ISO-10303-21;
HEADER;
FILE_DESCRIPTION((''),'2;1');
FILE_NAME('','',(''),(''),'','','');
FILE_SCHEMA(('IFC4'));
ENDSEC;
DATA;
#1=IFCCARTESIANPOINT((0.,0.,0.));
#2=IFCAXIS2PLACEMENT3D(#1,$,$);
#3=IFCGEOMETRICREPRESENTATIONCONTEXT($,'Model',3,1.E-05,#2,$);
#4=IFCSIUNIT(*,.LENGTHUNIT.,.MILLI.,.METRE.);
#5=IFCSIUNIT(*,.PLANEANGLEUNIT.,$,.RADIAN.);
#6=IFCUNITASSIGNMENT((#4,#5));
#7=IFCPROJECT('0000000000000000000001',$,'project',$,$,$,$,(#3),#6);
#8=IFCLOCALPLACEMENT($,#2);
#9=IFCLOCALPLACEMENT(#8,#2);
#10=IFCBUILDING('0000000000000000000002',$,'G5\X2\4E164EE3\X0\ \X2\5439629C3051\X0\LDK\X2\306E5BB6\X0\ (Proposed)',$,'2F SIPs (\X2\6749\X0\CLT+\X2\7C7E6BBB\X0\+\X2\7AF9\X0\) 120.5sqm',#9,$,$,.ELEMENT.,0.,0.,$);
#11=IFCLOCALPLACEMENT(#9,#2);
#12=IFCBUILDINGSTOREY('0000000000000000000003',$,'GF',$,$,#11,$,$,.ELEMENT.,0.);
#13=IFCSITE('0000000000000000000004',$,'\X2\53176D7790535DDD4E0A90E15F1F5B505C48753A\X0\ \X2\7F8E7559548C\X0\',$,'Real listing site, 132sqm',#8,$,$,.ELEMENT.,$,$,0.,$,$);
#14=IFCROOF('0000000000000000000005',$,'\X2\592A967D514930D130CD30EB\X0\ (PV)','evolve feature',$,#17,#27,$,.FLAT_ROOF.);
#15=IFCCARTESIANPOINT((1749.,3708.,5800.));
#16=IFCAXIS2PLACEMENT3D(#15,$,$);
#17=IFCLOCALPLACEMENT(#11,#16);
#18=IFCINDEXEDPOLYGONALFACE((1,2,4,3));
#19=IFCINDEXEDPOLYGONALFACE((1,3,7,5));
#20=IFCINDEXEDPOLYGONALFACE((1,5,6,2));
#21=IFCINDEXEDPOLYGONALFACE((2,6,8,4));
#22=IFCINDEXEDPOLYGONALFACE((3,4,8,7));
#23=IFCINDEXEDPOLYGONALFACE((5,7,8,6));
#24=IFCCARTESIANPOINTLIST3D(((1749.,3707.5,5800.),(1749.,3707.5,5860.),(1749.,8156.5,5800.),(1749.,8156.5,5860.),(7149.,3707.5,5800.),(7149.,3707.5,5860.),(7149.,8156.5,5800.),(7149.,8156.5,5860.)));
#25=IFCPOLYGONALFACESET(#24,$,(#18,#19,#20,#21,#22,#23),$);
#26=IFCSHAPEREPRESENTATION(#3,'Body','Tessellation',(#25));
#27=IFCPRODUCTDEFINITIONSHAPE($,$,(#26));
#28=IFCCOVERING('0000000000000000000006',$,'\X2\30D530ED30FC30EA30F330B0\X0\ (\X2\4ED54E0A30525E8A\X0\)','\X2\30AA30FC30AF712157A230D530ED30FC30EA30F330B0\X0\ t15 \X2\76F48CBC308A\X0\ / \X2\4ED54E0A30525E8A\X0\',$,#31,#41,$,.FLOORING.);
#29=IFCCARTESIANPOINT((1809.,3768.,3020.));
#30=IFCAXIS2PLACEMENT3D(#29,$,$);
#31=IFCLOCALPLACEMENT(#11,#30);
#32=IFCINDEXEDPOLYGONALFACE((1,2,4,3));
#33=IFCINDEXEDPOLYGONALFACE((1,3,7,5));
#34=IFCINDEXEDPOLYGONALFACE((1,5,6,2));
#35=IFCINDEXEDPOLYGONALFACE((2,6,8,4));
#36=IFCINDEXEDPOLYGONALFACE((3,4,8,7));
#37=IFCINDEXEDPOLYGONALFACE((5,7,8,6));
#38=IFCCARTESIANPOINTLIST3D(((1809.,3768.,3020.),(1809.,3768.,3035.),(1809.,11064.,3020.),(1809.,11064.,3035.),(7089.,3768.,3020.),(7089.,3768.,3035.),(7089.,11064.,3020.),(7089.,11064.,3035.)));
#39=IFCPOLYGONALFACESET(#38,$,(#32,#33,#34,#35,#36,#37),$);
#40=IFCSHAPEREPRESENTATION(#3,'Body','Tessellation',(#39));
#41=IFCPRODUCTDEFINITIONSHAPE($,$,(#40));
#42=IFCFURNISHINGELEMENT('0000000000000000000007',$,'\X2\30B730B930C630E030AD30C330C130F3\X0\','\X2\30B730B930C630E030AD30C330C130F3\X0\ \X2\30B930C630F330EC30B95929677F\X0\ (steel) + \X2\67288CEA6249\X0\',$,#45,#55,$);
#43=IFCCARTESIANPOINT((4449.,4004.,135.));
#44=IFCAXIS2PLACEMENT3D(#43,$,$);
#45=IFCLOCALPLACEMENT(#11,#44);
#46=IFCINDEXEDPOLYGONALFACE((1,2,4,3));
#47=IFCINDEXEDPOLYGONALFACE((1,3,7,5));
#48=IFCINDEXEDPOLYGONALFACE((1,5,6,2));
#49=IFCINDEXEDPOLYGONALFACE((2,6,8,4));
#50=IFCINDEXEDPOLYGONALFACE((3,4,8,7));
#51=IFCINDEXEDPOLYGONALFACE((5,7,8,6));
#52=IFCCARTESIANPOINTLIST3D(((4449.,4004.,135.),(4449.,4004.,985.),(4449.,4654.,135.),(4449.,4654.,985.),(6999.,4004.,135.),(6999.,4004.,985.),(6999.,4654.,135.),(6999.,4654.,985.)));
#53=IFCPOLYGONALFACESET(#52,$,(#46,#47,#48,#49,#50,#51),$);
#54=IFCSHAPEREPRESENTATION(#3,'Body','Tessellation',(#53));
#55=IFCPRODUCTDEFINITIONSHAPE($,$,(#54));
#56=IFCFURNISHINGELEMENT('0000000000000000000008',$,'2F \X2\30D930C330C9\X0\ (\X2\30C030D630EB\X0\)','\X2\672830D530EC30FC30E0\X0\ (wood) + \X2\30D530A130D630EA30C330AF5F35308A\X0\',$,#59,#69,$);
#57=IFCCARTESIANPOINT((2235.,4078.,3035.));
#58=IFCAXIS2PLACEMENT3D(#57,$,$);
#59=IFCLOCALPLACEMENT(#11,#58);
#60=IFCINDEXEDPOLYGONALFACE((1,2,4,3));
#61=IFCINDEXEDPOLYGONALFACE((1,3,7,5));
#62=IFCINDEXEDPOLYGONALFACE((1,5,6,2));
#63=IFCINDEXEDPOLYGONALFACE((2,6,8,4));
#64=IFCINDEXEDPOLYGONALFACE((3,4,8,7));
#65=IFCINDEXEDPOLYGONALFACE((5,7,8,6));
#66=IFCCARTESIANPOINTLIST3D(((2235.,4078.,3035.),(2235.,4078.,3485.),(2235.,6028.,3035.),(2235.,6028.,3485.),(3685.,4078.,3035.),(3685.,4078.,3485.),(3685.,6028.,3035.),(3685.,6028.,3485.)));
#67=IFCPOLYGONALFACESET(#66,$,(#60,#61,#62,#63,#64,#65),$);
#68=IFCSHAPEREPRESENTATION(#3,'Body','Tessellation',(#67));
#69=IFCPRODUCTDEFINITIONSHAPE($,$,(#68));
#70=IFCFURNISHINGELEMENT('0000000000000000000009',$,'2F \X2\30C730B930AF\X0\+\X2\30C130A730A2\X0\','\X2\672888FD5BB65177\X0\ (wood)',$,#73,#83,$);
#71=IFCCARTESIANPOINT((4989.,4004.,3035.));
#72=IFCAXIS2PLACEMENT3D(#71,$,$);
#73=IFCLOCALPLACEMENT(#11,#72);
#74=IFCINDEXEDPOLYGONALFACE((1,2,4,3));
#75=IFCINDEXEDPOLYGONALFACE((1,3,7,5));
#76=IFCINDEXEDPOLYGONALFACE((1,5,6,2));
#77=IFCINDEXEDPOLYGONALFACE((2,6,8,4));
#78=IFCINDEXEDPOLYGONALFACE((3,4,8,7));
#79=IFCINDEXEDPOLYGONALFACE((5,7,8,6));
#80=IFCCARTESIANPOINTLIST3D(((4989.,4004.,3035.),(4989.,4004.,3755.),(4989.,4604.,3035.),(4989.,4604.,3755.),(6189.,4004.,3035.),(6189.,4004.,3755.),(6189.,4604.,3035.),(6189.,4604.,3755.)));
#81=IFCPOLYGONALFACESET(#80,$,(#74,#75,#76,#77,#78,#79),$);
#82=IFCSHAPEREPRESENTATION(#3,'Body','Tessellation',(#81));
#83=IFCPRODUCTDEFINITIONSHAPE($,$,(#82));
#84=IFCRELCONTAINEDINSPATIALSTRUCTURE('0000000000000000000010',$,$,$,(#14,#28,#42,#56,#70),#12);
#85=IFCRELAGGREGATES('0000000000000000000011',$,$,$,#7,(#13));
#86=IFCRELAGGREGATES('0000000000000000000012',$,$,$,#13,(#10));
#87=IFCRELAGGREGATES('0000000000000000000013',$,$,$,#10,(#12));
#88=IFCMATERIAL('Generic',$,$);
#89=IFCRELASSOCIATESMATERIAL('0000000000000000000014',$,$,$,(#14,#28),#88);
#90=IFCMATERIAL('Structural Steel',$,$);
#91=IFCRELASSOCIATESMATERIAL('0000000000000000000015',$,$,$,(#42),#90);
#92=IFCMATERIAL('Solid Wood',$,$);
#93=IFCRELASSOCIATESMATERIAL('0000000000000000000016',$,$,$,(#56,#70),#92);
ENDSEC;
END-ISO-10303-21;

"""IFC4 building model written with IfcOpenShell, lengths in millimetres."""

from ifc_helpers import new_model, si_unit, frame, frame_2d, origin, place, context, project, spatial, rectangle, extrude, material, element, save


model = new_model("IFC4")

# Units and contexts
model_context = context("Model", 3, precision=1e-05, world=origin())
ifc_project = project(units=[si_unit("LENGTHUNIT", "METRE", prefix="MILLI"), si_unit("PLANEANGLEUNIT", "RADIAN")], contexts=[model_context])

# Site, building, storey
site_placement = place(None, origin())
site = spatial("IfcSite", under=ifc_project, at=site_placement, Name="北海道川上郡弟子屈町 美留和", ObjectType="Real listing site, 132sqm", CompositionType="ELEMENT", RefElevation=0.0)
building_placement = place(site_placement, origin())
building = spatial("IfcBuilding", under=site, at=building_placement, Name="G5世代 吹抜けLDKの家 (Proposed)", ObjectType="2F SIPs (杉CLT+籾殻+竹) 120.5sqm", CompositionType="ELEMENT", ElevationOfRefHeight=0.0, ElevationOfTerrain=0.0)
storey_placement = place(building_placement, origin())
storey = spatial("IfcBuildingStorey", under=building, at=storey_placement, Name="GF", CompositionType="ELEMENT", Elevation=0.0)

# Shared definitions
ifc_material_1 = material(Name="Solid Wood")

# Shared definitions
ifc_material_2 = material(Name="Generic")

# Roof
ifc_material_3 = material(Name="Structural Steel")
roof_1_placement = place(storey_placement, frame((1749.0, 3708.0, 5800.0)))
element("IfcRoof", 1, at=roof_1_placement, inside=storey, material=ifc_material_2, Name="太陽光パネル (PV)", Description="evolve feature", PredefinedType="FLAT_ROOF", context=model_context, shape_type="SweptSolid", body=[
    extrude(rectangle(XDim=5400.0, YDim=4449.0, at=frame_2d((2700.0, 2224.0))), frame((1749.0, 3708.0, 5800.0)), (0.0, 0.0, 1.0), 60.0),
])

# Covering
covering_placement = place(storey_placement, frame((1809.0, 3768.0, 3020.0)))
element("IfcCovering", 2, at=covering_placement, inside=storey, material=ifc_material_2, Name="フローリング (仕上げ床)", Description="オーク無垢フローリング t15 直貼り / 仕上げ床", PredefinedType="FLOORING", context=model_context, shape_type="SweptSolid", body=[
    extrude(rectangle(XDim=5280.0, YDim=7296.0, at=frame_2d((2640.0, 3648.0))), frame((1809.0, 3768.0, 3020.0)), (0.0, 0.0, 1.0), 15.0),
])

# Furnishing elements
furnishing_1_placement = place(storey_placement, frame((4449.0, 4004.0, 135.0)))
element("IfcFurnishingElement", 3, at=furnishing_1_placement, inside=storey, material=ifc_material_3, Name="システムキッチン", Description="システムキッチン ステンレス天板 (steel) + 木質扉", context=model_context, shape_type="SweptSolid", body=[
    extrude(rectangle(XDim=2550.0, YDim=650.0, at=frame_2d((1275.0, 325.0))), frame((4449.0, 4004.0, 135.0)), (0.0, 0.0, 1.0), 850.0),
])
furnishing_2_placement = place(storey_placement, frame((2235.0, 4078.0, 3035.0)))
element("IfcFurnishingElement", 4, at=furnishing_2_placement, inside=storey, material=ifc_material_1, Name="2F ベッド (ダブル)", Description="木フレーム (wood) + ファブリック張り", context=model_context, shape_type="SweptSolid", body=[
    extrude(rectangle(XDim=1450.0, YDim=1950.0, at=frame_2d((725.0, 975.0))), frame((2235.0, 4078.0, 3035.0)), (0.0, 0.0, 1.0), 450.0),
])
furnishing_3_placement = place(storey_placement, frame((4989.0, 4004.0, 3035.0)))
element("IfcFurnishingElement", 5, at=furnishing_3_placement, inside=storey, material=ifc_material_1, Name="2F デスク+チェア", Description="木製家具 (wood)", context=model_context, shape_type="SweptSolid", body=[
    extrude(rectangle(XDim=1200.0, YDim=600.0, at=frame_2d((600.0, 300.0))), frame((4989.0, 4004.0, 3035.0)), (0.0, 0.0, 1.0), 720.0),
])

save(model, "model.ifc")
